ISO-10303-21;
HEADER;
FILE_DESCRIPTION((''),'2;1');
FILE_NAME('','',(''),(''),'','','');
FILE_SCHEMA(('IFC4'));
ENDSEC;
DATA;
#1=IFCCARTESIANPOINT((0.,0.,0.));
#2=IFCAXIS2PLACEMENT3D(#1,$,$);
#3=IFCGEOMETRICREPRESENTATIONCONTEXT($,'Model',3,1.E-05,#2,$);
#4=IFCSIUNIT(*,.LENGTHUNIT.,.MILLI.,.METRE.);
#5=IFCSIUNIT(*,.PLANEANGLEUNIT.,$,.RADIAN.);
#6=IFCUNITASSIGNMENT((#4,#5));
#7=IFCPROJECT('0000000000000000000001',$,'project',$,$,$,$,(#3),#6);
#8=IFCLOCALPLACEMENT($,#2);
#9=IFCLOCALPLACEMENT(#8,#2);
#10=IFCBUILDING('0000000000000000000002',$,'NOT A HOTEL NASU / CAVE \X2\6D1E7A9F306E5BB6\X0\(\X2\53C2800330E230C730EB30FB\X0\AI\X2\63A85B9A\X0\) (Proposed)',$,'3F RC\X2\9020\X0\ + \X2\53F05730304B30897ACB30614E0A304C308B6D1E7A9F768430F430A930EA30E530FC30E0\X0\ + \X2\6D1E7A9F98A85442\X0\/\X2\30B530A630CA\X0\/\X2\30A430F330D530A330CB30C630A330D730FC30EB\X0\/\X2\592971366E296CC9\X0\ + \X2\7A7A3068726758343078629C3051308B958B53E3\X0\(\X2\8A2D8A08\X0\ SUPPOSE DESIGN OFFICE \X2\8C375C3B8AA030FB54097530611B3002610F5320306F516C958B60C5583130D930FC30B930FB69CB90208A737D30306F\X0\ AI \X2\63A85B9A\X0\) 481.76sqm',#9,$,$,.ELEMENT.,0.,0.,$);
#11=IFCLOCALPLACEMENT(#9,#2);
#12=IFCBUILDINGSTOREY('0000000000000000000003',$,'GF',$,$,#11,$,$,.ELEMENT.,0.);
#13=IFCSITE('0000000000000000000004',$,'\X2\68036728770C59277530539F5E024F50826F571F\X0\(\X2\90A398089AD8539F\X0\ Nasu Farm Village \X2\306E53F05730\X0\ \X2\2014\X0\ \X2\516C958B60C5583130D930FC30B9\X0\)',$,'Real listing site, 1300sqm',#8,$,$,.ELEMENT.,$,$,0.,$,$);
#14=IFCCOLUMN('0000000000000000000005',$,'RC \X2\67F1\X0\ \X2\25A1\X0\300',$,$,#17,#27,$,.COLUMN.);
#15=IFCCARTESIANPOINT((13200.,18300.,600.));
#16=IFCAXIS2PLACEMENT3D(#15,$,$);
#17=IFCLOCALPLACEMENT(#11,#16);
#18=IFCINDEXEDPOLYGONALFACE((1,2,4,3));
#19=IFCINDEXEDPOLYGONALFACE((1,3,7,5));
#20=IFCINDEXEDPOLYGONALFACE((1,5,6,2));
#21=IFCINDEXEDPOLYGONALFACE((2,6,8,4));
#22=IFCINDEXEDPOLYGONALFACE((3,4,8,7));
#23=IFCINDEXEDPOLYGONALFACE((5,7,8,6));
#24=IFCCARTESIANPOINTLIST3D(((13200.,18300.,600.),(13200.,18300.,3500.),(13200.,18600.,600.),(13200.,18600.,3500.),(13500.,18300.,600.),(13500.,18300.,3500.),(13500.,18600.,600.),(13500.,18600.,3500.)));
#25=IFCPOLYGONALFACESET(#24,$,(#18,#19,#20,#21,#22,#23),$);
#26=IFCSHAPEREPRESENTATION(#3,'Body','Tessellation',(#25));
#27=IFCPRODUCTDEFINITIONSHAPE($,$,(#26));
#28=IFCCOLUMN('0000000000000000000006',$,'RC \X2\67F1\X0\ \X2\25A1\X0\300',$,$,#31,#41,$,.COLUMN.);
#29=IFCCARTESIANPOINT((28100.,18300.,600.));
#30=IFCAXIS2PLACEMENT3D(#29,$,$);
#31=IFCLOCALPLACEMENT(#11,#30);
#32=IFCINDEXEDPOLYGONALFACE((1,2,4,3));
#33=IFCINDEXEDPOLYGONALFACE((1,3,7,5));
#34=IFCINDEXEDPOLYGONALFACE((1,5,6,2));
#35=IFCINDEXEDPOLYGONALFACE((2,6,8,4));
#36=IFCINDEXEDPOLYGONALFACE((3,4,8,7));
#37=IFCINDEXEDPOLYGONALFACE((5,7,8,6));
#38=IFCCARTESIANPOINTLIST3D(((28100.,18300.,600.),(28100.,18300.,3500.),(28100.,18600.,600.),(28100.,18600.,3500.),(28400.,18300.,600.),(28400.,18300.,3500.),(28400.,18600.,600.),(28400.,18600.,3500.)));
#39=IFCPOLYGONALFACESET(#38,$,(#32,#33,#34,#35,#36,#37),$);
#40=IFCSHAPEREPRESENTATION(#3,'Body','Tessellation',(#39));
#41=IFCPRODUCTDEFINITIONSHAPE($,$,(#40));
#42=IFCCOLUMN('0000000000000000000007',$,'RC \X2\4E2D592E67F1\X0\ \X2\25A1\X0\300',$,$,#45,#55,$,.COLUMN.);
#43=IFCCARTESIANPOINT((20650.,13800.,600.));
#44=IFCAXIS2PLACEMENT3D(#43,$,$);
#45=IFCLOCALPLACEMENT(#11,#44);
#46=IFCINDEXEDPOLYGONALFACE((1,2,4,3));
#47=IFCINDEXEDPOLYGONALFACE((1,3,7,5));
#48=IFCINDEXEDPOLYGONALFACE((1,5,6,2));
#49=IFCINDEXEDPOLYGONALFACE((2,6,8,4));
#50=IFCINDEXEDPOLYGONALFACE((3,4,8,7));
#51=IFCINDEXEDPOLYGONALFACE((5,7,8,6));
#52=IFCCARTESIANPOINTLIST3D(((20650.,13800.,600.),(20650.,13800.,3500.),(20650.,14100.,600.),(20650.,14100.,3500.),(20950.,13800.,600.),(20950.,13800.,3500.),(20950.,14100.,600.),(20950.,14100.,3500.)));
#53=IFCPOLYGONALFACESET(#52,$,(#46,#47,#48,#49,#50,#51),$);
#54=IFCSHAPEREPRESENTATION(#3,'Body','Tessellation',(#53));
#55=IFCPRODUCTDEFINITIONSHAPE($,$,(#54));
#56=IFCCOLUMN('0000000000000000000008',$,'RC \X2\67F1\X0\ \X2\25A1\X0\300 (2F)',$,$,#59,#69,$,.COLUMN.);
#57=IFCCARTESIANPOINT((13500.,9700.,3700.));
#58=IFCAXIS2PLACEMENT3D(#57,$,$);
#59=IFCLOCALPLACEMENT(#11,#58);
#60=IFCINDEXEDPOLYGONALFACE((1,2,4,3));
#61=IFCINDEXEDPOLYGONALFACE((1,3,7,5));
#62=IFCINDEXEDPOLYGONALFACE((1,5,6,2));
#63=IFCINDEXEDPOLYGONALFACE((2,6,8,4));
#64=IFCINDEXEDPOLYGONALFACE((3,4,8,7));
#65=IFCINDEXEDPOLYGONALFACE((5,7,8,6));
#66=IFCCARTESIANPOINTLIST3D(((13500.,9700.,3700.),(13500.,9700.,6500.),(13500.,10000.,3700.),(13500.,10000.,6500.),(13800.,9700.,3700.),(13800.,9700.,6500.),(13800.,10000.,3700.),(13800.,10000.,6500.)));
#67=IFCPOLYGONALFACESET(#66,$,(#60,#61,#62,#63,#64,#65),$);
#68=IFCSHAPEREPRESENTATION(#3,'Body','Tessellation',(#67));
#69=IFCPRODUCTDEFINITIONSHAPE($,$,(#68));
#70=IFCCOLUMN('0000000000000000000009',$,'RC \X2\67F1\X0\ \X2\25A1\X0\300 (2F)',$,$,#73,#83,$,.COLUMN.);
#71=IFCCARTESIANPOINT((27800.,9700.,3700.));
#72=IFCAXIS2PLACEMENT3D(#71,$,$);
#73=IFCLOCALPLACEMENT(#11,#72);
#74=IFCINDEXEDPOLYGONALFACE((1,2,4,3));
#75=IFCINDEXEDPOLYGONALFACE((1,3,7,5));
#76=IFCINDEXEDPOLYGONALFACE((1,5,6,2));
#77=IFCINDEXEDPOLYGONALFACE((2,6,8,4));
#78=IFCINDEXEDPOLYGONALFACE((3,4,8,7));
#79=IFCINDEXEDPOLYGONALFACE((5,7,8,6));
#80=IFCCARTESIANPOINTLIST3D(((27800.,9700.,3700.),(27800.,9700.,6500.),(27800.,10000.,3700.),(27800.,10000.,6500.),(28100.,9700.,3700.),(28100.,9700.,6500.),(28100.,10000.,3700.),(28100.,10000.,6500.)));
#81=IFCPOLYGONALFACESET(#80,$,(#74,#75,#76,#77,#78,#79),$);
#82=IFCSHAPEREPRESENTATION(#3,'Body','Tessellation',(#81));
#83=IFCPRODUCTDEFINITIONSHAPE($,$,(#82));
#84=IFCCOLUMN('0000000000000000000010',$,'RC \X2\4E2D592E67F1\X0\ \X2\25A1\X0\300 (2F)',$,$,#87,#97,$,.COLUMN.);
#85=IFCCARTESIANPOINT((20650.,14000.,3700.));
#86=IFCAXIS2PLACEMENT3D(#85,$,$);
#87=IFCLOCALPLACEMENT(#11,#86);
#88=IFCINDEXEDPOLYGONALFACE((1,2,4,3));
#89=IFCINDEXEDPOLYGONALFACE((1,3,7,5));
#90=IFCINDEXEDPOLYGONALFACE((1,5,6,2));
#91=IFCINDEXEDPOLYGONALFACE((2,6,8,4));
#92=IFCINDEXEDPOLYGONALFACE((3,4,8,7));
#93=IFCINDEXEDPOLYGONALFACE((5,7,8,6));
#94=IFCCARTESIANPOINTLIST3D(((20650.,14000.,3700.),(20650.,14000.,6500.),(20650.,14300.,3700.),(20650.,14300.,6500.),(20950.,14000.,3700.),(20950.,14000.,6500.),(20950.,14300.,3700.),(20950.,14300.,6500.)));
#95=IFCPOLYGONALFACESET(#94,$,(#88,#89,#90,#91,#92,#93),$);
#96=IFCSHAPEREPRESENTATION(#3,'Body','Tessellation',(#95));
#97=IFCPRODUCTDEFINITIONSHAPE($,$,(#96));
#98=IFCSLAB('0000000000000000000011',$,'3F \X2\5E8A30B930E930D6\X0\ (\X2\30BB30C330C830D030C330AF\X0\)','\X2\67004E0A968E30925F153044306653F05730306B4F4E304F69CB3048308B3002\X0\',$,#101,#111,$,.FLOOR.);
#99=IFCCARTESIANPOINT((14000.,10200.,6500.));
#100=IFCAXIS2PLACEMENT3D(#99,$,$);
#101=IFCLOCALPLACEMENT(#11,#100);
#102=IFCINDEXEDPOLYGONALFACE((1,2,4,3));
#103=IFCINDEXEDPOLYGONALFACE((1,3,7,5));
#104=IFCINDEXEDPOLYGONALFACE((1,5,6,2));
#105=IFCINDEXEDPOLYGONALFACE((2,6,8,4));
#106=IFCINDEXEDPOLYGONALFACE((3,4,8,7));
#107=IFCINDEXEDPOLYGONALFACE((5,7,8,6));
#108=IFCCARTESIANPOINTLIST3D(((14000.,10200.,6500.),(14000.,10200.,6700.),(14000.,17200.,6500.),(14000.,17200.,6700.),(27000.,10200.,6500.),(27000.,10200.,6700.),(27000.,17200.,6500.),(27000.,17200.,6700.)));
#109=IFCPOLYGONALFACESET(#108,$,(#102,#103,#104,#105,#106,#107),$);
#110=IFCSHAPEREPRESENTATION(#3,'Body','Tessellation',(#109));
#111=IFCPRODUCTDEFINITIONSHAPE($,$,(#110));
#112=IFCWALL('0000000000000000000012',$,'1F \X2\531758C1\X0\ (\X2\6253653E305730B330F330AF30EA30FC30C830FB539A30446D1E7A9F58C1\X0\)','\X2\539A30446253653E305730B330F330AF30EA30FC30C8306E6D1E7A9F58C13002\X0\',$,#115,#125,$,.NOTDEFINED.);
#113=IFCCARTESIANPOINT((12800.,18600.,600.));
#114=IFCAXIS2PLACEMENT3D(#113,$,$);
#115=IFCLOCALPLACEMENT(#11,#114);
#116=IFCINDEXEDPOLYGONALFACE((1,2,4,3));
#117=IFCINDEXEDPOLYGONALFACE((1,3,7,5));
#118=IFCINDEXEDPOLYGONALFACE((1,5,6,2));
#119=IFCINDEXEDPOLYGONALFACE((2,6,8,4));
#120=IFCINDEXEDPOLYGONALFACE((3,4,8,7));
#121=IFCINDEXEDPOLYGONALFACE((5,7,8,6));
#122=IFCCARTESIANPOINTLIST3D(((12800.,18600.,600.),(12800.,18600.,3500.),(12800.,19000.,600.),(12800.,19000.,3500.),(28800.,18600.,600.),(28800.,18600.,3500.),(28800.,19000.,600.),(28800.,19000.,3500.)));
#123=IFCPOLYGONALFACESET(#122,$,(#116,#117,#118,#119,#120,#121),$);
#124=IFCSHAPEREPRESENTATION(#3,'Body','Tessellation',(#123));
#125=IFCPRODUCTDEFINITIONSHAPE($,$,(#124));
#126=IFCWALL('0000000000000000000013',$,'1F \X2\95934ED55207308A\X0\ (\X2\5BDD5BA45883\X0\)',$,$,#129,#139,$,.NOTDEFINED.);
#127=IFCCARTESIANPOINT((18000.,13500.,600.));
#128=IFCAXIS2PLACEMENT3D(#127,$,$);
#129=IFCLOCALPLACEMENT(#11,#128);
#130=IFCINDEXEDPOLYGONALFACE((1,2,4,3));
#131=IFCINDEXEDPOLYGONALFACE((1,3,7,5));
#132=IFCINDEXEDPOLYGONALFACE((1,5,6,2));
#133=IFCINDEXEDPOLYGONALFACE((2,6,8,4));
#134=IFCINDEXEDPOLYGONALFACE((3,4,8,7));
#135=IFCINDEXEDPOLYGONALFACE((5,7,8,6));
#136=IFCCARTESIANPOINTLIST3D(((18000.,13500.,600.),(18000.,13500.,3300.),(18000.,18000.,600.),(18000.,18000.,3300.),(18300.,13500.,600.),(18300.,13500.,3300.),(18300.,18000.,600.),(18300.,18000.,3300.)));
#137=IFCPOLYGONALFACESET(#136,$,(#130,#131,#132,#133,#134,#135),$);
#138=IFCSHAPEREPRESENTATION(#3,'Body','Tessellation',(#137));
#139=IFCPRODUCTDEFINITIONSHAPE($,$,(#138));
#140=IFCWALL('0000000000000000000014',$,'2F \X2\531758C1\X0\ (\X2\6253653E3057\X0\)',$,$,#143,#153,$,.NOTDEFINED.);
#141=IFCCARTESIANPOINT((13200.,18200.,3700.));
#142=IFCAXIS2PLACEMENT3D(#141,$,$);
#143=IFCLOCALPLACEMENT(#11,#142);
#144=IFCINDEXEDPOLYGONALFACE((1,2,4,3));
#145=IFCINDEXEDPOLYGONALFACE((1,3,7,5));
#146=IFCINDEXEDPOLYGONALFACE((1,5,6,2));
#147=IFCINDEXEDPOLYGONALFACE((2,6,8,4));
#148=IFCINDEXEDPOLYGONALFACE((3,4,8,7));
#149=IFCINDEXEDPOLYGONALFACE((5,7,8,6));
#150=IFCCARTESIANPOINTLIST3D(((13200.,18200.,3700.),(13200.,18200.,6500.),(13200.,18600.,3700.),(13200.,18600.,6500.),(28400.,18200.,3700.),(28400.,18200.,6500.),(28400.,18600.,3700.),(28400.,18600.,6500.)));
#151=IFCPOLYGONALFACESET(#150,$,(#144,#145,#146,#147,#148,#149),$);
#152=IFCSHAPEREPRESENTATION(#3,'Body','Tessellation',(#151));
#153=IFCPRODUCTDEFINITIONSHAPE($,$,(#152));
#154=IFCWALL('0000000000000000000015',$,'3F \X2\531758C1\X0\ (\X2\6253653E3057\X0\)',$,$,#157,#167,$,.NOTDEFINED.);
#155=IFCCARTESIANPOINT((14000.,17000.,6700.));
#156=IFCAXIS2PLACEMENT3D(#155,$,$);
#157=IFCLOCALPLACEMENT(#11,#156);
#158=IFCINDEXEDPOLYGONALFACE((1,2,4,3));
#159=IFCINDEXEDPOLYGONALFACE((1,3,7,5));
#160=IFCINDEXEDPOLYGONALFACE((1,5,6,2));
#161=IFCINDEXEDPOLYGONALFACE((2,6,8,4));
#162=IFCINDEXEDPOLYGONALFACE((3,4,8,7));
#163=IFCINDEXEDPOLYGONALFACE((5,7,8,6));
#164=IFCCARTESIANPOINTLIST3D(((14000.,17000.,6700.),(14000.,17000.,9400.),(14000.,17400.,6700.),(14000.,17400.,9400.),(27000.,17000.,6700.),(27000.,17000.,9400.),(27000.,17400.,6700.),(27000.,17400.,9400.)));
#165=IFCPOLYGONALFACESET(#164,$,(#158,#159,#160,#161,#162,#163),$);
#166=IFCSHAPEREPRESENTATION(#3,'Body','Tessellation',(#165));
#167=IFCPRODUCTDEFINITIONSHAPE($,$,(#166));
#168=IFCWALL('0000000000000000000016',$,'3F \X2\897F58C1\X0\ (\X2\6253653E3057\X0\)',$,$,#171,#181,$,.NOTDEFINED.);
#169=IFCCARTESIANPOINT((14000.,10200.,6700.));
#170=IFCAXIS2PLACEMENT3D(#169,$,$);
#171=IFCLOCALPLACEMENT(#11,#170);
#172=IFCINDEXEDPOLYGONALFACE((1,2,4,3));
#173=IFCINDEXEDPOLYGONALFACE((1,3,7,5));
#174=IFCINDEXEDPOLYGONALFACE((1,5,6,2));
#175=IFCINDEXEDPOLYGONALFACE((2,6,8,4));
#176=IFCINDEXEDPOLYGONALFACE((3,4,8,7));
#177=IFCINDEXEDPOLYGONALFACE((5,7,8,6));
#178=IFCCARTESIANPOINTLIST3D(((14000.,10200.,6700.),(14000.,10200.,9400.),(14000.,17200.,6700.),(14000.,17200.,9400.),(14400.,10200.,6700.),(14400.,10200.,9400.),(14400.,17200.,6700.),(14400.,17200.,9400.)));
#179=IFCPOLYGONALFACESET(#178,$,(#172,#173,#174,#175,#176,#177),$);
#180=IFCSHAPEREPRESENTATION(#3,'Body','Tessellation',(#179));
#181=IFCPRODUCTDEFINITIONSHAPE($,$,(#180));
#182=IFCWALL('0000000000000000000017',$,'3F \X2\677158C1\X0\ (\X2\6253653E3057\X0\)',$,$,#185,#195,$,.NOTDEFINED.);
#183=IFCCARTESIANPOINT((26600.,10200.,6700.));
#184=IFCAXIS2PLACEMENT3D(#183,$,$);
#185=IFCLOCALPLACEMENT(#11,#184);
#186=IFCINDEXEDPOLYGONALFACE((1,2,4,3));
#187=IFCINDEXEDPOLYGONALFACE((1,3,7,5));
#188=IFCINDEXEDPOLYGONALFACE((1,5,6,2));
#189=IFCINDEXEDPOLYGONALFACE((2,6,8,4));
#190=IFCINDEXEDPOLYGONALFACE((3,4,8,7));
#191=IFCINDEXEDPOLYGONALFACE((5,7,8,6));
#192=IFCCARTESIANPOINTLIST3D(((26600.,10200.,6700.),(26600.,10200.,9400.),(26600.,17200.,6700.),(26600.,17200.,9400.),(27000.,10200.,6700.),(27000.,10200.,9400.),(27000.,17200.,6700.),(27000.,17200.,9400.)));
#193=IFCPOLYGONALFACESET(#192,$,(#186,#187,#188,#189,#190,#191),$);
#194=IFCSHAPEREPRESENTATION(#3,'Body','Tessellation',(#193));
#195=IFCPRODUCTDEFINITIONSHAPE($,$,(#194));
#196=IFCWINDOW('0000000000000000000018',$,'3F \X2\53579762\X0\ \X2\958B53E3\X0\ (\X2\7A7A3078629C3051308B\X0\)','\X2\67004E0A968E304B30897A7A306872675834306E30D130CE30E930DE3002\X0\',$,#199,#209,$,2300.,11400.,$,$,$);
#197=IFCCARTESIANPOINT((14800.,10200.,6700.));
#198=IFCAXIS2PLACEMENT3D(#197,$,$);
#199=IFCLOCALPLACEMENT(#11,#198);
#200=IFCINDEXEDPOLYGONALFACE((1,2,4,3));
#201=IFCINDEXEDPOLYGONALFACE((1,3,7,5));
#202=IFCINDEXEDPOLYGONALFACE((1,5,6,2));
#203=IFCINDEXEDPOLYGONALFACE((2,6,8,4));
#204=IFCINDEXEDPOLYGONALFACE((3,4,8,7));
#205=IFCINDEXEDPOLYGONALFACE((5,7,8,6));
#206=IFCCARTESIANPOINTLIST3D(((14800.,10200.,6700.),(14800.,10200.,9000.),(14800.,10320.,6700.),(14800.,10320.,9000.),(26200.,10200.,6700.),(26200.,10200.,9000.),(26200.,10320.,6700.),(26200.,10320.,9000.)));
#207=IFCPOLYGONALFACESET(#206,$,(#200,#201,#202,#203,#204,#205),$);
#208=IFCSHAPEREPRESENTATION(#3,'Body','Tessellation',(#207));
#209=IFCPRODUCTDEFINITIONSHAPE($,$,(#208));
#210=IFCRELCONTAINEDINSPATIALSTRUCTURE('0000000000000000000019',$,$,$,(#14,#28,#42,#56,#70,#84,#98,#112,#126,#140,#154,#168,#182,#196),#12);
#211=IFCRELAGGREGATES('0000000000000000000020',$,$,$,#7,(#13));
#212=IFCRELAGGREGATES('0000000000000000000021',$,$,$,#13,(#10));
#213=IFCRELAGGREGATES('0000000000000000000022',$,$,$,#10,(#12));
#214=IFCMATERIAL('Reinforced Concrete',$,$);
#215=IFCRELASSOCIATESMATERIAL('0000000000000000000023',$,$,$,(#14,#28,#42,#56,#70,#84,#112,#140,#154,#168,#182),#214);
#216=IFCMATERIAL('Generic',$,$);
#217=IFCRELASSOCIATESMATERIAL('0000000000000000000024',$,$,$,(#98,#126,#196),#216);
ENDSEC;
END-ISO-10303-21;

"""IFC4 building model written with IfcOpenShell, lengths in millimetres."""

from ifc_helpers import new_model, si_unit, frame, frame_2d, origin, place, context, project, spatial, rectangle, extrude, material, element, save


model = new_model("IFC4")

# Units and contexts
model_context = context("Model", 3, precision=1e-05, world=origin())
ifc_project = project(units=[si_unit("LENGTHUNIT", "METRE", prefix="MILLI"), si_unit("PLANEANGLEUNIT", "RADIAN")], contexts=[model_context])

# Site, building, storey
site_placement = place(None, origin())
site = spatial("IfcSite", under=ifc_project, at=site_placement, Name="栃木県大田原市佐良土(那須高原 Nasu Farm Village の台地 — 公開情報ベース)", ObjectType="Real listing site, 1300sqm", CompositionType="ELEMENT", RefElevation=0.0)
building_placement = place(site_placement, origin())
building = spatial("IfcBuilding", under=site, at=building_placement, Name="NOT A HOTEL NASU / CAVE 洞窟の家(参考モデル・AI推定) (Proposed)", ObjectType="3F RC造 + 台地から立ち上がる洞窟的ヴォリューム + 洞窟風呂/サウナ/インフィニティプール/天然温泉 + 空と牧場へ抜ける開口(設計 SUPPOSE DESIGN OFFICE 谷尻誠・吉田愛。意匠は公開情報ベース・構造詳細は AI 推定) 481.76sqm", CompositionType="ELEMENT", ElevationOfRefHeight=0.0, ElevationOfTerrain=0.0)
storey_placement = place(building_placement, origin())
storey = spatial("IfcBuildingStorey", under=building, at=storey_placement, Name="GF", CompositionType="ELEMENT", Elevation=0.0)

# Columns
ifc_material_1 = material(Name="Reinforced Concrete")
column_1_placement = place(storey_placement, frame((13200.0, 18300.0, 600.0)))
element("IfcColumn", 1, at=column_1_placement, inside=storey, material=ifc_material_1, Name="RC 柱 □300", PredefinedType="COLUMN", context=model_context, shape_type="SweptSolid", body=[
    extrude(rectangle(XDim=300.0, YDim=300.0, at=frame_2d((150.0, 150.0))), frame((13200.0, 18300.0, 600.0)), (0.0, 0.0, 1.0), 2900.0),
])
column_2_placement = place(storey_placement, frame((28100.0, 18300.0, 600.0)))
element("IfcColumn", 2, at=column_2_placement, inside=storey, material=ifc_material_1, Name="RC 柱 □300", PredefinedType="COLUMN", context=model_context, shape_type="SweptSolid", body=[
    extrude(rectangle(XDim=300.0, YDim=300.0, at=frame_2d((150.0, 150.0))), frame((28100.0, 18300.0, 600.0)), (0.0, 0.0, 1.0), 2900.0),
])
column_3_placement = place(storey_placement, frame((20650.0, 13800.0, 600.0)))
element("IfcColumn", 3, at=column_3_placement, inside=storey, material=ifc_material_1, Name="RC 中央柱 □300", PredefinedType="COLUMN", context=model_context, shape_type="SweptSolid", body=[
    extrude(rectangle(XDim=300.0, YDim=300.0, at=frame_2d((150.0, 150.0))), frame((20650.0, 13800.0, 600.0)), (0.0, 0.0, 1.0), 2900.0),
])
column_4_placement = place(storey_placement, frame((13500.0, 9700.0, 3700.0)))
element("IfcColumn", 4, at=column_4_placement, inside=storey, material=ifc_material_1, Name="RC 柱 □300 (2F)", PredefinedType="COLUMN", context=model_context, shape_type="SweptSolid", body=[
    extrude(rectangle(XDim=300.0, YDim=300.0, at=frame_2d((150.0, 150.0))), frame((13500.0, 9700.0, 3700.0)), (0.0, 0.0, 1.0), 2800.0),
])
column_5_placement = place(storey_placement, frame((27800.0, 9700.0, 3700.0)))
element("IfcColumn", 5, at=column_5_placement, inside=storey, material=ifc_material_1, Name="RC 柱 □300 (2F)", PredefinedType="COLUMN", context=model_context, shape_type="SweptSolid", body=[
    extrude(rectangle(XDim=300.0, YDim=300.0, at=frame_2d((150.0, 150.0))), frame((27800.0, 9700.0, 3700.0)), (0.0, 0.0, 1.0), 2800.0),
])
column_6_placement = place(storey_placement, frame((20650.0, 14000.0, 3700.0)))
element("IfcColumn", 6, at=column_6_placement, inside=storey, material=ifc_material_1, Name="RC 中央柱 □300 (2F)", PredefinedType="COLUMN", context=model_context, shape_type="SweptSolid", body=[
    extrude(rectangle(XDim=300.0, YDim=300.0, at=frame_2d((150.0, 150.0))), frame((20650.0, 14000.0, 3700.0)), (0.0, 0.0, 1.0), 2800.0),
])

# Slab
ifc_material_2 = material(Name="Generic")
slab_placement = place(storey_placement, frame((14000.0, 10200.0, 6500.0)))
element("IfcSlab", 7, at=slab_placement, inside=storey, material=ifc_material_2, Name="3F 床スラブ (セットバック)", Description="最上階を引いて台地に低く構える。", PredefinedType="FLOOR", context=model_context, shape_type="SweptSolid", body=[
    extrude(rectangle(XDim=13000.0, YDim=7000.0, at=frame_2d((6500.0, 3500.0))), frame((14000.0, 10200.0, 6500.0)), (0.0, 0.0, 1.0), 200.0),
])

# Walls
wall_1_placement = place(storey_placement, frame((12800.0, 18600.0, 600.0)))
element("IfcWall", 8, at=wall_1_placement, inside=storey, material=ifc_material_1, Name="1F 北壁 (打放しコンクリート・厚い洞窟壁)", Description="厚い打放しコンクリートの洞窟壁。", PredefinedType="NOTDEFINED", context=model_context, shape_type="SweptSolid", body=[
    extrude(rectangle(XDim=16000.0, YDim=400.0, at=frame_2d((8000.0, 200.0))), frame((12800.0, 18600.0, 600.0)), (0.0, 0.0, 1.0), 2900.0),
])
wall_2_placement = place(storey_placement, frame((18000.0, 13500.0, 600.0)))
element("IfcWall", 9, at=wall_2_placement, inside=storey, material=ifc_material_2, Name="1F 間仕切り (寝室境)", PredefinedType="NOTDEFINED", context=model_context, shape_type="SweptSolid", body=[
    extrude(rectangle(XDim=300.0, YDim=4500.0, at=frame_2d((150.0, 2250.0))), frame((18000.0, 13500.0, 600.0)), (0.0, 0.0, 1.0), 2700.0),
])
wall_3_placement = place(storey_placement, frame((13200.0, 18200.0, 3700.0)))
element("IfcWall", 10, at=wall_3_placement, inside=storey, material=ifc_material_1, Name="2F 北壁 (打放し)", PredefinedType="NOTDEFINED", context=model_context, shape_type="SweptSolid", body=[
    extrude(rectangle(XDim=15200.0, YDim=400.0, at=frame_2d((7600.0, 200.0))), frame((13200.0, 18200.0, 3700.0)), (0.0, 0.0, 1.0), 2800.0),
])
wall_4_placement = place(storey_placement, frame((14000.0, 17000.0, 6700.0)))
element("IfcWall", 11, at=wall_4_placement, inside=storey, material=ifc_material_1, Name="3F 北壁 (打放し)", PredefinedType="NOTDEFINED", context=model_context, shape_type="SweptSolid", body=[
    extrude(rectangle(XDim=13000.0, YDim=400.0, at=frame_2d((6500.0, 200.0))), frame((14000.0, 17000.0, 6700.0)), (0.0, 0.0, 1.0), 2700.0),
])
wall_5_placement = place(storey_placement, frame((14000.0, 10200.0, 6700.0)))
element("IfcWall", 12, at=wall_5_placement, inside=storey, material=ifc_material_1, Name="3F 西壁 (打放し)", PredefinedType="NOTDEFINED", context=model_context, shape_type="SweptSolid", body=[
    extrude(rectangle(XDim=400.0, YDim=7000.0, at=frame_2d((200.0, 3500.0))), frame((14000.0, 10200.0, 6700.0)), (0.0, 0.0, 1.0), 2700.0),
])
wall_6_placement = place(storey_placement, frame((26600.0, 10200.0, 6700.0)))
element("IfcWall", 13, at=wall_6_placement, inside=storey, material=ifc_material_1, Name="3F 東壁 (打放し)", PredefinedType="NOTDEFINED", context=model_context, shape_type="SweptSolid", body=[
    extrude(rectangle(XDim=400.0, YDim=7000.0, at=frame_2d((200.0, 3500.0))), frame((26600.0, 10200.0, 6700.0)), (0.0, 0.0, 1.0), 2700.0),
])

# Window
window_1_placement = place(storey_placement, frame((14800.0, 10200.0, 6700.0)))
element("IfcWindow", 14, at=window_1_placement, inside=storey, material=ifc_material_2, Name="3F 南面 開口 (空へ抜ける)", Description="最上階から空と牧場のパノラマ。", OverallHeight=2300.0, OverallWidth=11400.0, context=model_context, shape_type="SweptSolid", body=[
    extrude(rectangle(XDim=11400.0, YDim=120.0, at=frame_2d((5700.0, 60.0))), frame((14800.0, 10200.0, 6700.0)), (0.0, 0.0, 1.0), 2300.0),
])

save(model, "model.ifc")
